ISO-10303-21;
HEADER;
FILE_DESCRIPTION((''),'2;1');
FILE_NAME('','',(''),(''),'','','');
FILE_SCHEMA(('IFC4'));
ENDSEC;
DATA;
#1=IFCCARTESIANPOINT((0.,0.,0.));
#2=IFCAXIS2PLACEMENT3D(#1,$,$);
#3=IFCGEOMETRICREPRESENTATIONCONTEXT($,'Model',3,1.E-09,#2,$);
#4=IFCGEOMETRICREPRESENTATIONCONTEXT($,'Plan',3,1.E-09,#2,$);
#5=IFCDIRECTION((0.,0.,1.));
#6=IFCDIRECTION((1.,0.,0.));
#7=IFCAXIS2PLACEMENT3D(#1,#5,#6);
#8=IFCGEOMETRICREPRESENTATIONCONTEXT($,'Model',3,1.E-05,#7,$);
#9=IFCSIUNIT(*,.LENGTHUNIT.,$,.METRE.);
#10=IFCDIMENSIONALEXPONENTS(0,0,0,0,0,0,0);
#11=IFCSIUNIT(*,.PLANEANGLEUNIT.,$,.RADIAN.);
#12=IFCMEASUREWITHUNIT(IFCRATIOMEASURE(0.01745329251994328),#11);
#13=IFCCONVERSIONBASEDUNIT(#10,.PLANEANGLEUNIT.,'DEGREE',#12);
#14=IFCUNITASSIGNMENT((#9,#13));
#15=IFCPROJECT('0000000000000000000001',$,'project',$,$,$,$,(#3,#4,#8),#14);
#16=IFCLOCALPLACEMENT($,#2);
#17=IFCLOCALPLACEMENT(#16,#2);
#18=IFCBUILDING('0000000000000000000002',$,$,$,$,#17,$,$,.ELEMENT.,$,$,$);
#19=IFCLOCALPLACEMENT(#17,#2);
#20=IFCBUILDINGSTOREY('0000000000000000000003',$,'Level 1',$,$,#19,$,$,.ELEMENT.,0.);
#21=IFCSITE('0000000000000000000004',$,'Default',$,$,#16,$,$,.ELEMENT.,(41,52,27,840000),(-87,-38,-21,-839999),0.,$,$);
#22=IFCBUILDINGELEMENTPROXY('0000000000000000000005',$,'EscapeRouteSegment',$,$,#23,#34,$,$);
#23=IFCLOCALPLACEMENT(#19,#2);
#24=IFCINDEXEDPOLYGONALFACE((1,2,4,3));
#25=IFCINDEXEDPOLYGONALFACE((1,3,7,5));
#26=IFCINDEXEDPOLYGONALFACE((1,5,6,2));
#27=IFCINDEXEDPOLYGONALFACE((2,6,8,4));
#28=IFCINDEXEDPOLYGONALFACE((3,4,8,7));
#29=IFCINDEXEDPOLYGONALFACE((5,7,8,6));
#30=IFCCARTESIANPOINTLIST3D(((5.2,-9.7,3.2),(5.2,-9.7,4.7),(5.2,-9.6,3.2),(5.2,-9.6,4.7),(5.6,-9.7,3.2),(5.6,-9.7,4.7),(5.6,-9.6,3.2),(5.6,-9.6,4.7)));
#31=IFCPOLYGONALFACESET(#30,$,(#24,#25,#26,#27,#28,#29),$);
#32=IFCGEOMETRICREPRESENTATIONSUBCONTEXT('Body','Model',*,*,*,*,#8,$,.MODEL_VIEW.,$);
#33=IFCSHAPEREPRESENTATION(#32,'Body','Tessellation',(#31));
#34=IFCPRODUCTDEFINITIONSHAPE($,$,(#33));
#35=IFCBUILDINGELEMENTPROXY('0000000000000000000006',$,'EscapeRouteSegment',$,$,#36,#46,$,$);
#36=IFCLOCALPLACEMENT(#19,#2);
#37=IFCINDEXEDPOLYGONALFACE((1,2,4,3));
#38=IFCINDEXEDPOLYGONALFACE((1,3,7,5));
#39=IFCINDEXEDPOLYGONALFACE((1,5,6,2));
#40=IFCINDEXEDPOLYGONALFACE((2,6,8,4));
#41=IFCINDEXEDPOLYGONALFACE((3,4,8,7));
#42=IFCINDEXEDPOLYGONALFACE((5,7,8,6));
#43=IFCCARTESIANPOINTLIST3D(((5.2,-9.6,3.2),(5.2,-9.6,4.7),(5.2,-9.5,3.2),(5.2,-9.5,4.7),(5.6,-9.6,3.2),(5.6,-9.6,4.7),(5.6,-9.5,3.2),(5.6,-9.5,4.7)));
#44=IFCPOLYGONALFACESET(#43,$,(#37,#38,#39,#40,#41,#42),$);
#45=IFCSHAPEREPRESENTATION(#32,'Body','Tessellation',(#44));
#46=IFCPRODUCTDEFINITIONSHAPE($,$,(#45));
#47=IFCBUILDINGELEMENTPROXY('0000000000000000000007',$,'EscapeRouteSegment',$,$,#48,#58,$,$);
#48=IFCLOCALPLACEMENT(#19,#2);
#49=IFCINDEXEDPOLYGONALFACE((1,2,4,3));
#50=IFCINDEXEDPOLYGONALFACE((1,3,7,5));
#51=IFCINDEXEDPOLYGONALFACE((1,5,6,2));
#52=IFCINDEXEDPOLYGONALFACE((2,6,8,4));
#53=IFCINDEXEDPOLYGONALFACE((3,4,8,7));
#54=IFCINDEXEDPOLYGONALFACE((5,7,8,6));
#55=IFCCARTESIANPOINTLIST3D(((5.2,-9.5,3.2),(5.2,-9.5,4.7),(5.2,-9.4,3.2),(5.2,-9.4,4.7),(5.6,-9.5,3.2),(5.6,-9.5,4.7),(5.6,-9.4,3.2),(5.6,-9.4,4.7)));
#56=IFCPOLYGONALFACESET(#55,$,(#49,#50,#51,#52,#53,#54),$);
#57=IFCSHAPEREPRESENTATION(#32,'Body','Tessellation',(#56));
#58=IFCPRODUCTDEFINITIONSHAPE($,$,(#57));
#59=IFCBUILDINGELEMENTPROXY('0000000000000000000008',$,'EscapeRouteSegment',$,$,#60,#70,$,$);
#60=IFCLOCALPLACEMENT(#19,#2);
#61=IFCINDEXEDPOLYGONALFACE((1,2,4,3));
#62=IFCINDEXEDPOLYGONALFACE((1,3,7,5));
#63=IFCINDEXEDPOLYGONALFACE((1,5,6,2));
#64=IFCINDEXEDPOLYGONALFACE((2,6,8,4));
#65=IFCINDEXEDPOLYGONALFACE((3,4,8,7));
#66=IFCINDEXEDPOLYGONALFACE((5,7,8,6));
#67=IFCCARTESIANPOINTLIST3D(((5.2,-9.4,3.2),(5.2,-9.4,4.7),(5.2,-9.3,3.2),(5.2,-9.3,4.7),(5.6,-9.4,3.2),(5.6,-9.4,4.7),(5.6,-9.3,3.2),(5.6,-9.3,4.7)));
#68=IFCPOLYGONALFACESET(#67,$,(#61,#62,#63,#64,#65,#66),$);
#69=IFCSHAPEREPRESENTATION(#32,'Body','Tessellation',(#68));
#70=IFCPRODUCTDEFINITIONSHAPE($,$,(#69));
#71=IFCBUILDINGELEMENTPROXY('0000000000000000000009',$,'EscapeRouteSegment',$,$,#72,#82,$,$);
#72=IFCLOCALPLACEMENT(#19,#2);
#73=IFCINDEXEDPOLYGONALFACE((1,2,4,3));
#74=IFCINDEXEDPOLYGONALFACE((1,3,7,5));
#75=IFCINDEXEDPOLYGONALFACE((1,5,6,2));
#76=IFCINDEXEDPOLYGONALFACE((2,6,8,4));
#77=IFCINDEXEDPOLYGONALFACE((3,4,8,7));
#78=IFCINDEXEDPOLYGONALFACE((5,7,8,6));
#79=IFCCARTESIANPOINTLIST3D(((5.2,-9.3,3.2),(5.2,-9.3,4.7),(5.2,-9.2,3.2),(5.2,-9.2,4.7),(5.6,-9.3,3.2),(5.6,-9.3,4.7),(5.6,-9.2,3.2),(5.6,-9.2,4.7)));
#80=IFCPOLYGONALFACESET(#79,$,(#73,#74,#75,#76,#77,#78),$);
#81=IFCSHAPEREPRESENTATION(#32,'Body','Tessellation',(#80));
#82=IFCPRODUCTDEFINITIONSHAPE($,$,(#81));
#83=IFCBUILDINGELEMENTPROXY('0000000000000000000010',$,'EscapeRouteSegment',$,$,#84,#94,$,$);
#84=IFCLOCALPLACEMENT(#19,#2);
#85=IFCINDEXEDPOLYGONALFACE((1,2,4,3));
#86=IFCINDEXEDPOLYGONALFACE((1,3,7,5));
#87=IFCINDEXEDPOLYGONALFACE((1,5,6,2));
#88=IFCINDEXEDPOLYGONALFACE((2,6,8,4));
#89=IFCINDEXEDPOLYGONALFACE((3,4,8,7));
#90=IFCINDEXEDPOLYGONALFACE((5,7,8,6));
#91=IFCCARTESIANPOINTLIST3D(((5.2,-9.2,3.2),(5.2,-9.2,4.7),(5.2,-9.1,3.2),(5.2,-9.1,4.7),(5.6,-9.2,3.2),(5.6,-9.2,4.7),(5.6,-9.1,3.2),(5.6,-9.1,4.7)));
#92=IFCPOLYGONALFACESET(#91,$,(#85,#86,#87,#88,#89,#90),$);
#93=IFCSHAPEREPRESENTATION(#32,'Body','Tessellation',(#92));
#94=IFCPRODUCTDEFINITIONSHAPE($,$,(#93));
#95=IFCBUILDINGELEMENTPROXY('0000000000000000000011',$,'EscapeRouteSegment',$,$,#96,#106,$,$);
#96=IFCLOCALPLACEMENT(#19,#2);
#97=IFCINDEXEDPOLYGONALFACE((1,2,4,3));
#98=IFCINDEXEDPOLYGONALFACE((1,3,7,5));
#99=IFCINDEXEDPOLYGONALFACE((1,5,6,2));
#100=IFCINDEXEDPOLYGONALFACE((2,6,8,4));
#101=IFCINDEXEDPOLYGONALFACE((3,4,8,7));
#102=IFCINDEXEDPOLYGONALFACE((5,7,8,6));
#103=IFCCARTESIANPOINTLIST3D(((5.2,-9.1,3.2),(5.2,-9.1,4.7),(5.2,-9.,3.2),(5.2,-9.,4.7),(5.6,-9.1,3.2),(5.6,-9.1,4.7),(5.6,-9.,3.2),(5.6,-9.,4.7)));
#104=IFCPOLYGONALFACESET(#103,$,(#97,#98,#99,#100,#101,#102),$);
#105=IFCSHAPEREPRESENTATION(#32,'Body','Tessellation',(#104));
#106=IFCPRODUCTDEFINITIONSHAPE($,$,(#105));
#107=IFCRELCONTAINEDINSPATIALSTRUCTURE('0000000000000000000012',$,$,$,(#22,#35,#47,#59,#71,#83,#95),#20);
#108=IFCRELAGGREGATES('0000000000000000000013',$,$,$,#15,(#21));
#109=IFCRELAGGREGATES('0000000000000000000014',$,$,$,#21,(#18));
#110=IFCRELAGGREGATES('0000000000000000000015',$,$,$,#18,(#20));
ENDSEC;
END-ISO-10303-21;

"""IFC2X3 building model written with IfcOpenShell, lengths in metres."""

from ifc_helpers import new_model, entity, si_unit, converted_unit, frame, origin, origin_with_axes, place, context, subcontext, project, spatial, polyline, outline, extrude, element, save


model = new_model("IFC2X3")

# Units and contexts
model_context_1 = context("Model", 3, precision=1e-09, world=origin())
plan_context = context("Plan", 3, precision=1e-09, world=origin())
model_context_2 = context("Model", 3, precision=1e-05, world=origin_with_axes())
body_context = subcontext(model_context_2, "Body", "Model", "MODEL_VIEW")
ifc_project = project(units=[si_unit("LENGTHUNIT", "METRE"), converted_unit("PLANEANGLEUNIT", "DEGREE", entity("IfcRatioMeasure", 0.01745329251994328), si_unit("PLANEANGLEUNIT", "RADIAN"), dimensions=[0, 0, 0, 0, 0, 0, 0])], contexts=[model_context_1, plan_context, model_context_2])

# Site, building, storey
site_placement = place(None, origin())
site = spatial("IfcSite", under=ifc_project, at=site_placement, Name="Default", CompositionType="ELEMENT", RefLatitude=(41, 52, 27, 840000), RefLongitude=(-87, -38, -21, -839999), RefElevation=0.0)
building_placement = place(site_placement, origin())
building = spatial("IfcBuilding", under=site, at=building_placement, CompositionType="ELEMENT")
storey_placement = place(building_placement, origin())
storey = spatial("IfcBuildingStorey", under=building, at=storey_placement, Name="Level 1", CompositionType="ELEMENT", Elevation=0.0)

# Building element proxies
proxy_1_placement = place(storey_placement, frame((5.4, -9.7, 3.2), z_axis=(0.0, 0.0, 1.0), x_axis=(0.0, 1.0, 0.0)))
element("IfcBuildingElementProxy", 1, at=proxy_1_placement, inside=storey, Name="EscapeRouteSegment", context=body_context, shape_type="SweptSolid", body=[
    extrude(outline(polyline([(0.0, -0.2), (0.0, 0.2), (0.1, 0.2), (0.1, -0.2), (0.0, -0.2)])), origin_with_axes(), (0.0, 0.0, 1.0), 1.5),
])
for number, where, z_axis, x_axis, name in (
    (2, (5.4, -9.6, 3.2), (0.0, 0.0, 1.0), (0.0, 1.0, 0.0), "EscapeRouteSegment"),
    (3, (5.4, -9.5, 3.2), (0.0, 0.0, 1.0), (0.0, 1.0, 0.0), "EscapeRouteSegment"),
):
    element("IfcBuildingElementProxy", number, at=place(storey_placement, frame(where, z_axis=z_axis, x_axis=x_axis)), inside=storey, Name=name, context=body_context, shape_type="SweptSolid", body=[
        extrude(outline(polyline([(0.0, -0.2), (0.0, 0.2), (0.1, 0.2), (0.1, -0.2), (0.0, -0.2)])), origin_with_axes(), (0.0, 0.0, 1.0), 1.5),
    ])
proxy_2_placement = place(storey_placement, frame((5.4, -9.4, 3.2), z_axis=(0.0, 0.0, 1.0), x_axis=(0.0, 1.0, 0.0)))
element("IfcBuildingElementProxy", 4, at=proxy_2_placement, inside=storey, Name="EscapeRouteSegment", context=body_context, shape_type="SweptSolid", body=[
    extrude(outline(polyline([(0.0, -0.2), (0.0, 0.2), (0.1, 0.2), (0.1, -0.2), (0.0, -0.2)])), origin_with_axes(), (0.0, 0.0, 1.0), 1.5),
])
proxy_3_placement = place(storey_placement, frame((5.4, -9.3, 3.2), z_axis=(0.0, 0.0, 1.0), x_axis=(0.0, 1.0, 0.0)))
element("IfcBuildingElementProxy", 5, at=proxy_3_placement, inside=storey, Name="EscapeRouteSegment", context=body_context, shape_type="SweptSolid", body=[
    extrude(outline(polyline([(0.0, -0.2), (0.0, 0.2), (0.1, 0.2), (0.1, -0.2), (0.0, -0.2)])), origin_with_axes(), (0.0, 0.0, 1.0), 1.5),
])
proxy_4_placement = place(storey_placement, frame((5.4, -9.2, 3.2), z_axis=(0.0, 0.0, 1.0), x_axis=(0.0, 1.0, 0.0)))
element("IfcBuildingElementProxy", 6, at=proxy_4_placement, inside=storey, Name="EscapeRouteSegment", context=body_context, shape_type="SweptSolid", body=[
    extrude(outline(polyline([(0.0, -0.2), (0.0, 0.2), (0.1, 0.2), (0.1, -0.2), (0.0, -0.2)])), origin_with_axes(), (0.0, 0.0, 1.0), 1.5),
])
proxy_5_placement = place(storey_placement, frame((5.4, -9.1, 3.2), z_axis=(0.0, 0.0, 1.0), x_axis=(0.0, 1.0, 0.0)))
element("IfcBuildingElementProxy", 7, at=proxy_5_placement, inside=storey, Name="EscapeRouteSegment", context=body_context, shape_type="SweptSolid", body=[
    extrude(outline(polyline([(0.0, -0.2), (0.0, 0.2), (0.1, 0.2), (0.1, -0.2), (0.0, -0.2)])), origin_with_axes(), (0.0, 0.0, 1.0), 1.5),
])

save(model, "model.ifc")
